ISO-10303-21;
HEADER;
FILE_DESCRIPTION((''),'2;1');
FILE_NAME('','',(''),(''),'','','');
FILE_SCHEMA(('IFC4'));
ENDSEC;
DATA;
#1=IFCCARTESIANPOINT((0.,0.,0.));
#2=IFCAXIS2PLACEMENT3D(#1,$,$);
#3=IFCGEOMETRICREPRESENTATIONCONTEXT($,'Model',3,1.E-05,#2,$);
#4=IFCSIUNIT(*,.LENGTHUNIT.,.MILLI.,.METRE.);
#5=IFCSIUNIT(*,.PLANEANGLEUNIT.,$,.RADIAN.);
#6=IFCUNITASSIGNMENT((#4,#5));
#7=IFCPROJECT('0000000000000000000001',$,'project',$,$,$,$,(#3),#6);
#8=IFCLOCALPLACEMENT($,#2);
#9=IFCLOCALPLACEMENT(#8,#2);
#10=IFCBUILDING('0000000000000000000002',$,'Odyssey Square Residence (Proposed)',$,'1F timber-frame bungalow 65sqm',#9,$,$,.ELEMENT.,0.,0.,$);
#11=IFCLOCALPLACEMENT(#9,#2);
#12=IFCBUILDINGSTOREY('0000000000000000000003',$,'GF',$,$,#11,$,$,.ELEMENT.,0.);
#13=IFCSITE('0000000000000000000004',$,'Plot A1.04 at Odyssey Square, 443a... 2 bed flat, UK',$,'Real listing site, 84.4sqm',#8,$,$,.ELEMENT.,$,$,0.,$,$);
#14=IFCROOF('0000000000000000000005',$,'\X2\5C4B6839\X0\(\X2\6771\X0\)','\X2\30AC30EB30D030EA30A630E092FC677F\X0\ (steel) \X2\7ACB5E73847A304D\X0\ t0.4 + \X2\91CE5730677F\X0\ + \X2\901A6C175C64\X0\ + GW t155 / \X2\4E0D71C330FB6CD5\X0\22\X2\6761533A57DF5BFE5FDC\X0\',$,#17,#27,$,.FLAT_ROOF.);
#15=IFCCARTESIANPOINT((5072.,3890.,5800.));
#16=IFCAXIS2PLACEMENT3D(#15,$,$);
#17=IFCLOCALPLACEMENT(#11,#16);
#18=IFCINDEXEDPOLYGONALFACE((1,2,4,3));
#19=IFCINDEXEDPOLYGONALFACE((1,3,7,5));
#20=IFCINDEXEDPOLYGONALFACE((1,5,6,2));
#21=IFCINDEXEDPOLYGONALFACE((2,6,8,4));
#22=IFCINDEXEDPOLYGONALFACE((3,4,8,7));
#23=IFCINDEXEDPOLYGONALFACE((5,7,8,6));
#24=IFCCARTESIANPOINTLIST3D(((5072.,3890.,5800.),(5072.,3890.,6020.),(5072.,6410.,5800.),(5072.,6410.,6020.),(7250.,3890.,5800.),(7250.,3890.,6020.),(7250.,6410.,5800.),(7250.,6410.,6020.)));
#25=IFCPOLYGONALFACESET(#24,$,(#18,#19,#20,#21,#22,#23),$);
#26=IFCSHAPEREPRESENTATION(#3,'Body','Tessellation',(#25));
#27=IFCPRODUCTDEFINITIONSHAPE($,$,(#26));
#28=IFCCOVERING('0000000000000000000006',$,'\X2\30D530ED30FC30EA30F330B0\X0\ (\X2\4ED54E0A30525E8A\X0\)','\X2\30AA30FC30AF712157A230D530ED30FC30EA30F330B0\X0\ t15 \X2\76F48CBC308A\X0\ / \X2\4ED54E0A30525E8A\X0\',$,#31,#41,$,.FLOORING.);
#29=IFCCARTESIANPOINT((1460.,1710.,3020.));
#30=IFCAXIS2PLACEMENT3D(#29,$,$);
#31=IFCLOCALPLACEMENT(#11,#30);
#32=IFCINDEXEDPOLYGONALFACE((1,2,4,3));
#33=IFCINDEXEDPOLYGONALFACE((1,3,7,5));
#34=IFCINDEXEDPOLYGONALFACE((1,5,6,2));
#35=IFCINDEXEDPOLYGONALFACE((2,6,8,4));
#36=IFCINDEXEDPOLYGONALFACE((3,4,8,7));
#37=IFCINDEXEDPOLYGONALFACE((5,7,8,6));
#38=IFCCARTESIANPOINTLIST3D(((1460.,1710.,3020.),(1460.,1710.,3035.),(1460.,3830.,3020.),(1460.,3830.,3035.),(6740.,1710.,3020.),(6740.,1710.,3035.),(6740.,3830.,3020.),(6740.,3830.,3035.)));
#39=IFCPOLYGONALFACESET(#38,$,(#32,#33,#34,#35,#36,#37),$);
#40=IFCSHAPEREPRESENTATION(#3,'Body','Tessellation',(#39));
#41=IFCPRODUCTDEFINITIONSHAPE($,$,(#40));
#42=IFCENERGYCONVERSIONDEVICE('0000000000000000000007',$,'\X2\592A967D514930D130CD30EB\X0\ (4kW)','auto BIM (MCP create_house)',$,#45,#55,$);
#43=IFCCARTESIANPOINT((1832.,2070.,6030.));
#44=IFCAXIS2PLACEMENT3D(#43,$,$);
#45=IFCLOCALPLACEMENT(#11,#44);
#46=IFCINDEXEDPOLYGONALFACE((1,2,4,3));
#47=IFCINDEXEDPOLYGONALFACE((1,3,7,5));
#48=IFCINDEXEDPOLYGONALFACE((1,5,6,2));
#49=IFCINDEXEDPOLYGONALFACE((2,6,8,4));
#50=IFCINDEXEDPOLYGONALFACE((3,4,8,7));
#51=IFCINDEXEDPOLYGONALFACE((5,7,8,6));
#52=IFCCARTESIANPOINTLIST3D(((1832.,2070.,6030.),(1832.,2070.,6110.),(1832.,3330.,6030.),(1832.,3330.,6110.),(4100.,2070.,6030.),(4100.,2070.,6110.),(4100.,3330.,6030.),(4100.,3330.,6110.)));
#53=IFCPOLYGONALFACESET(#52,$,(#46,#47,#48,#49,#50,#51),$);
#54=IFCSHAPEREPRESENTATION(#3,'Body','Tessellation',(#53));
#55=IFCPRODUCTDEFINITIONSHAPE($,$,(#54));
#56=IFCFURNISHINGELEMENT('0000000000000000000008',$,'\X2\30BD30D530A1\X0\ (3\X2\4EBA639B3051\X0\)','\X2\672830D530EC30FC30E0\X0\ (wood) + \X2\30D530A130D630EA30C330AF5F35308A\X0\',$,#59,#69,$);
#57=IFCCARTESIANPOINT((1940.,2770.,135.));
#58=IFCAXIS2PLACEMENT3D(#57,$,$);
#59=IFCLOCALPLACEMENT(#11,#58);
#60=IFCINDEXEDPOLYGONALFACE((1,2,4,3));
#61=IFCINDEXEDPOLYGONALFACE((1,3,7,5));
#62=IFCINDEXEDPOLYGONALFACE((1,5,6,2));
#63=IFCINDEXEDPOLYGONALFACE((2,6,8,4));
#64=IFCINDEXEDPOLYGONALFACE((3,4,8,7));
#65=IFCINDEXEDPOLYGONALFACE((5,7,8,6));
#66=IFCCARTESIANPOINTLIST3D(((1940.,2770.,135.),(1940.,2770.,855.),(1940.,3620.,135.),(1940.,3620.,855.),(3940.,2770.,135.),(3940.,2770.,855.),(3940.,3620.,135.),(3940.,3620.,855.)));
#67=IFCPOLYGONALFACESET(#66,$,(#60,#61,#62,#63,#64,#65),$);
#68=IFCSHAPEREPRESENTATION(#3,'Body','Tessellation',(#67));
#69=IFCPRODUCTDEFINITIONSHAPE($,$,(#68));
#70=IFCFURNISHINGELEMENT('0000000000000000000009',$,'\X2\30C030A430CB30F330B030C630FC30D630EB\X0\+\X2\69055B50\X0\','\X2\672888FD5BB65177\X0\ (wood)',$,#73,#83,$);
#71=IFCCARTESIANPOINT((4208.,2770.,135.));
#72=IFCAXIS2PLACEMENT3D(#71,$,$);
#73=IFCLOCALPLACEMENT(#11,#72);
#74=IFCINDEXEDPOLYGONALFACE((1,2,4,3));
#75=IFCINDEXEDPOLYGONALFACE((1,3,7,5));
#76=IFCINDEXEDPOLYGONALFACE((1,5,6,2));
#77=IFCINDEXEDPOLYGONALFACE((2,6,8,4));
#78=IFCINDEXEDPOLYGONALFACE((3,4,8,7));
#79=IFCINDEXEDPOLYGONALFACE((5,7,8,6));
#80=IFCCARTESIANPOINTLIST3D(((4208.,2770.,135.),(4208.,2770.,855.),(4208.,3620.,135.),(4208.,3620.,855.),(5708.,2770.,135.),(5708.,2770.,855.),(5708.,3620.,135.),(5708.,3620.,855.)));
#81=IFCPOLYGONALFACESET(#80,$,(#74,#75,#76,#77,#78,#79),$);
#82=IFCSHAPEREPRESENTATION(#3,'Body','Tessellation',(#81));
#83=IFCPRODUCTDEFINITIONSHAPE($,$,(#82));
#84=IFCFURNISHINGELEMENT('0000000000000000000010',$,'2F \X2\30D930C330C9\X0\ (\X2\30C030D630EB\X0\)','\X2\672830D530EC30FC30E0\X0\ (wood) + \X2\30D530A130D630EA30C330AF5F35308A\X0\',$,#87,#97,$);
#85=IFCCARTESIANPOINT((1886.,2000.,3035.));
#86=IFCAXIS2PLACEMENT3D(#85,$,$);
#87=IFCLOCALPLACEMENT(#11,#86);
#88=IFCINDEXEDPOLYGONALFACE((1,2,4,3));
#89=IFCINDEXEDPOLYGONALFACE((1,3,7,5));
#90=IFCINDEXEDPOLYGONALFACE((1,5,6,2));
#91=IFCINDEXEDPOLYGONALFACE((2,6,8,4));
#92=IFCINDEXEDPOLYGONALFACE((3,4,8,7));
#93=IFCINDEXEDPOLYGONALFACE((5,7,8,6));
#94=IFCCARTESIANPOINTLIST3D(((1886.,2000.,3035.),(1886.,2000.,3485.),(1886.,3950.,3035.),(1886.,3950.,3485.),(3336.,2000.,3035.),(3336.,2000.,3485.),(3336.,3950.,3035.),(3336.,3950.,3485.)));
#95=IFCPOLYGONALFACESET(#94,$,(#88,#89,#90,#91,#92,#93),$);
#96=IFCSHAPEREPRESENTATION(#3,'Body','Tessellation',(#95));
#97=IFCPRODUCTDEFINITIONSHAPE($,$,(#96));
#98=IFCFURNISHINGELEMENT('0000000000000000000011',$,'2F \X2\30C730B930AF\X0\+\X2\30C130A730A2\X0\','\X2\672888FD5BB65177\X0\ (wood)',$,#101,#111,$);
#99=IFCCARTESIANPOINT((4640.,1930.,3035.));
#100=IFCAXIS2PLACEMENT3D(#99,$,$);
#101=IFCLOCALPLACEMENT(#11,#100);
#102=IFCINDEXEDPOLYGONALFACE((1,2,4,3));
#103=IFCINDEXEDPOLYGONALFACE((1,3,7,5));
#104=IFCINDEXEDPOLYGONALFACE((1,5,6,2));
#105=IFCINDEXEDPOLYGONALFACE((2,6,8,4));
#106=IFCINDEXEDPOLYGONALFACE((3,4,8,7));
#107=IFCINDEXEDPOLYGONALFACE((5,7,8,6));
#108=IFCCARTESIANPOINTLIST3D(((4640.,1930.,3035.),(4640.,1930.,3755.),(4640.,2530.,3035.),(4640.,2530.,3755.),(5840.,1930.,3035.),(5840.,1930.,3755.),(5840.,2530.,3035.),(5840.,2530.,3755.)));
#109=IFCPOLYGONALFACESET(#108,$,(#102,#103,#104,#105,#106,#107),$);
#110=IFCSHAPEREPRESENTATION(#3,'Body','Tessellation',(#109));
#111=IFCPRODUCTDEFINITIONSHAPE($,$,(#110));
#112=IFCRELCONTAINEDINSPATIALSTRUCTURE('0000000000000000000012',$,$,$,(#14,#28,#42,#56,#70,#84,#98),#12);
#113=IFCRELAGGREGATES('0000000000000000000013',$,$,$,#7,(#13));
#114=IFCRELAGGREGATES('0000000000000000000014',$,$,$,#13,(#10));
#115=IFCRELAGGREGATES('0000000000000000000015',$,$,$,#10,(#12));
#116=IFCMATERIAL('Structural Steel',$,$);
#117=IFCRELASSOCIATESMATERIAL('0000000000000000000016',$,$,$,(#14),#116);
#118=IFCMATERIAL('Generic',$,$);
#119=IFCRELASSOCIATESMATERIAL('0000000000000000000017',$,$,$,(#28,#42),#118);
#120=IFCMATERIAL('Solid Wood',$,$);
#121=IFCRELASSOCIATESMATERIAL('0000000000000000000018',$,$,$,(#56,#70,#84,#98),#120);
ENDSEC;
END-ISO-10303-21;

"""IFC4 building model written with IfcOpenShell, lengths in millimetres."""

from ifc_helpers import new_model, si_unit, frame, frame_2d, origin, place, context, project, spatial, rectangle, extrude, material, element, save


model = new_model("IFC4")

# Units and contexts
model_context = context("Model", 3, precision=1e-05, world=origin())
ifc_project = project(units=[si_unit("LENGTHUNIT", "METRE", prefix="MILLI"), si_unit("PLANEANGLEUNIT", "RADIAN")], contexts=[model_context])

# Site, building, storey
site_placement = place(None, origin())
site = spatial("IfcSite", under=ifc_project, at=site_placement, Name="Plot A1.04 at Odyssey Square, 443a... 2 bed flat, UK", ObjectType="Real listing site, 84.4sqm", CompositionType="ELEMENT", RefElevation=0.0)
building_placement = place(site_placement, origin())
building = spatial("IfcBuilding", under=site, at=building_placement, Name="Odyssey Square Residence (Proposed)", ObjectType="1F timber-frame bungalow 65sqm", CompositionType="ELEMENT", ElevationOfRefHeight=0.0, ElevationOfTerrain=0.0)
storey_placement = place(building_placement, origin())
storey = spatial("IfcBuildingStorey", under=building, at=storey_placement, Name="GF", CompositionType="ELEMENT", Elevation=0.0)

# Shared definitions
ifc_material_1 = material(Name="Solid Wood")

# Roof
ifc_material_2 = material(Name="Structural Steel")
roof_1_placement = place(storey_placement, frame((5072.0, 3890.0, 5800.0)))
element("IfcRoof", 1, at=roof_1_placement, inside=storey, material=ifc_material_2, Name="屋根(東)", Description="ガルバリウム鋼板 (steel) 立平葺き t0.4 + 野地板 + 通気層 + GW t155 / 不燃・法22条区域対応", PredefinedType="FLAT_ROOF", context=model_context, shape_type="SweptSolid", body=[
    extrude(rectangle(XDim=2178.0, YDim=2520.0, at=frame_2d((1089.0, 1260.0))), frame((5072.0, 3890.0, 5800.0)), (0.0, 0.0, 1.0), 220.0),
])

# Covering
ifc_material_3 = material(Name="Generic")
covering_placement = place(storey_placement, frame((1460.0, 1710.0, 3020.0)))
element("IfcCovering", 2, at=covering_placement, inside=storey, material=ifc_material_3, Name="フローリング (仕上げ床)", Description="オーク無垢フローリング t15 直貼り / 仕上げ床", PredefinedType="FLOORING", context=model_context, shape_type="SweptSolid", body=[
    extrude(rectangle(XDim=5280.0, YDim=2120.0, at=frame_2d((2640.0, 1060.0))), frame((1460.0, 1710.0, 3020.0)), (0.0, 0.0, 1.0), 15.0),
])

# Energy conversion device
energy_conversion_device_placement = place(storey_placement, frame((1832.0, 2070.0, 6030.0)))
element("IfcEnergyConversionDevice", 3, at=energy_conversion_device_placement, inside=storey, material=ifc_material_3, Name="太陽光パネル (4kW)", Description="auto BIM (MCP create_house)", context=model_context, shape_type="SweptSolid", body=[
    extrude(rectangle(XDim=2268.0, YDim=1260.0, at=frame_2d((1134.0, 630.0))), frame((1832.0, 2070.0, 6030.0)), (0.0, 0.0, 1.0), 80.0),
])

# Furnishing elements
furnishing_1_placement = place(storey_placement, frame((1940.0, 2770.0, 135.0)))
element("IfcFurnishingElement", 4, at=furnishing_1_placement, inside=storey, material=ifc_material_1, Name="ソファ (3人掛け)", Description="木フレーム (wood) + ファブリック張り", context=model_context, shape_type="SweptSolid", body=[
    extrude(rectangle(XDim=2000.0, YDim=850.0, at=frame_2d((1000.0, 425.0))), frame((1940.0, 2770.0, 135.0)), (0.0, 0.0, 1.0), 720.0),
])
furnishing_2_placement = place(storey_placement, frame((4208.0, 2770.0, 135.0)))
element("IfcFurnishingElement", 5, at=furnishing_2_placement, inside=storey, material=ifc_material_1, Name="ダイニングテーブル+椅子", Description="木製家具 (wood)", context=model_context, shape_type="SweptSolid", body=[
    extrude(rectangle(XDim=1500.0, YDim=850.0, at=frame_2d((750.0, 425.0))), frame((4208.0, 2770.0, 135.0)), (0.0, 0.0, 1.0), 720.0),
])
furnishing_3_placement = place(storey_placement, frame((1886.0, 2000.0, 3035.0)))
element("IfcFurnishingElement", 6, at=furnishing_3_placement, inside=storey, material=ifc_material_1, Name="2F ベッド (ダブル)", Description="木フレーム (wood) + ファブリック張り", context=model_context, shape_type="SweptSolid", body=[
    extrude(rectangle(XDim=1450.0, YDim=1950.0, at=frame_2d((725.0, 975.0))), frame((1886.0, 2000.0, 3035.0)), (0.0, 0.0, 1.0), 450.0),
])
furnishing_4_placement = place(storey_placement, frame((4640.0, 1930.0, 3035.0)))
element("IfcFurnishingElement", 7, at=furnishing_4_placement, inside=storey, material=ifc_material_1, Name="2F デスク+チェア", Description="木製家具 (wood)", context=model_context, shape_type="SweptSolid", body=[
    extrude(rectangle(XDim=1200.0, YDim=600.0, at=frame_2d((600.0, 300.0))), frame((4640.0, 1930.0, 3035.0)), (0.0, 0.0, 1.0), 720.0),
])

save(model, "model.ifc")
